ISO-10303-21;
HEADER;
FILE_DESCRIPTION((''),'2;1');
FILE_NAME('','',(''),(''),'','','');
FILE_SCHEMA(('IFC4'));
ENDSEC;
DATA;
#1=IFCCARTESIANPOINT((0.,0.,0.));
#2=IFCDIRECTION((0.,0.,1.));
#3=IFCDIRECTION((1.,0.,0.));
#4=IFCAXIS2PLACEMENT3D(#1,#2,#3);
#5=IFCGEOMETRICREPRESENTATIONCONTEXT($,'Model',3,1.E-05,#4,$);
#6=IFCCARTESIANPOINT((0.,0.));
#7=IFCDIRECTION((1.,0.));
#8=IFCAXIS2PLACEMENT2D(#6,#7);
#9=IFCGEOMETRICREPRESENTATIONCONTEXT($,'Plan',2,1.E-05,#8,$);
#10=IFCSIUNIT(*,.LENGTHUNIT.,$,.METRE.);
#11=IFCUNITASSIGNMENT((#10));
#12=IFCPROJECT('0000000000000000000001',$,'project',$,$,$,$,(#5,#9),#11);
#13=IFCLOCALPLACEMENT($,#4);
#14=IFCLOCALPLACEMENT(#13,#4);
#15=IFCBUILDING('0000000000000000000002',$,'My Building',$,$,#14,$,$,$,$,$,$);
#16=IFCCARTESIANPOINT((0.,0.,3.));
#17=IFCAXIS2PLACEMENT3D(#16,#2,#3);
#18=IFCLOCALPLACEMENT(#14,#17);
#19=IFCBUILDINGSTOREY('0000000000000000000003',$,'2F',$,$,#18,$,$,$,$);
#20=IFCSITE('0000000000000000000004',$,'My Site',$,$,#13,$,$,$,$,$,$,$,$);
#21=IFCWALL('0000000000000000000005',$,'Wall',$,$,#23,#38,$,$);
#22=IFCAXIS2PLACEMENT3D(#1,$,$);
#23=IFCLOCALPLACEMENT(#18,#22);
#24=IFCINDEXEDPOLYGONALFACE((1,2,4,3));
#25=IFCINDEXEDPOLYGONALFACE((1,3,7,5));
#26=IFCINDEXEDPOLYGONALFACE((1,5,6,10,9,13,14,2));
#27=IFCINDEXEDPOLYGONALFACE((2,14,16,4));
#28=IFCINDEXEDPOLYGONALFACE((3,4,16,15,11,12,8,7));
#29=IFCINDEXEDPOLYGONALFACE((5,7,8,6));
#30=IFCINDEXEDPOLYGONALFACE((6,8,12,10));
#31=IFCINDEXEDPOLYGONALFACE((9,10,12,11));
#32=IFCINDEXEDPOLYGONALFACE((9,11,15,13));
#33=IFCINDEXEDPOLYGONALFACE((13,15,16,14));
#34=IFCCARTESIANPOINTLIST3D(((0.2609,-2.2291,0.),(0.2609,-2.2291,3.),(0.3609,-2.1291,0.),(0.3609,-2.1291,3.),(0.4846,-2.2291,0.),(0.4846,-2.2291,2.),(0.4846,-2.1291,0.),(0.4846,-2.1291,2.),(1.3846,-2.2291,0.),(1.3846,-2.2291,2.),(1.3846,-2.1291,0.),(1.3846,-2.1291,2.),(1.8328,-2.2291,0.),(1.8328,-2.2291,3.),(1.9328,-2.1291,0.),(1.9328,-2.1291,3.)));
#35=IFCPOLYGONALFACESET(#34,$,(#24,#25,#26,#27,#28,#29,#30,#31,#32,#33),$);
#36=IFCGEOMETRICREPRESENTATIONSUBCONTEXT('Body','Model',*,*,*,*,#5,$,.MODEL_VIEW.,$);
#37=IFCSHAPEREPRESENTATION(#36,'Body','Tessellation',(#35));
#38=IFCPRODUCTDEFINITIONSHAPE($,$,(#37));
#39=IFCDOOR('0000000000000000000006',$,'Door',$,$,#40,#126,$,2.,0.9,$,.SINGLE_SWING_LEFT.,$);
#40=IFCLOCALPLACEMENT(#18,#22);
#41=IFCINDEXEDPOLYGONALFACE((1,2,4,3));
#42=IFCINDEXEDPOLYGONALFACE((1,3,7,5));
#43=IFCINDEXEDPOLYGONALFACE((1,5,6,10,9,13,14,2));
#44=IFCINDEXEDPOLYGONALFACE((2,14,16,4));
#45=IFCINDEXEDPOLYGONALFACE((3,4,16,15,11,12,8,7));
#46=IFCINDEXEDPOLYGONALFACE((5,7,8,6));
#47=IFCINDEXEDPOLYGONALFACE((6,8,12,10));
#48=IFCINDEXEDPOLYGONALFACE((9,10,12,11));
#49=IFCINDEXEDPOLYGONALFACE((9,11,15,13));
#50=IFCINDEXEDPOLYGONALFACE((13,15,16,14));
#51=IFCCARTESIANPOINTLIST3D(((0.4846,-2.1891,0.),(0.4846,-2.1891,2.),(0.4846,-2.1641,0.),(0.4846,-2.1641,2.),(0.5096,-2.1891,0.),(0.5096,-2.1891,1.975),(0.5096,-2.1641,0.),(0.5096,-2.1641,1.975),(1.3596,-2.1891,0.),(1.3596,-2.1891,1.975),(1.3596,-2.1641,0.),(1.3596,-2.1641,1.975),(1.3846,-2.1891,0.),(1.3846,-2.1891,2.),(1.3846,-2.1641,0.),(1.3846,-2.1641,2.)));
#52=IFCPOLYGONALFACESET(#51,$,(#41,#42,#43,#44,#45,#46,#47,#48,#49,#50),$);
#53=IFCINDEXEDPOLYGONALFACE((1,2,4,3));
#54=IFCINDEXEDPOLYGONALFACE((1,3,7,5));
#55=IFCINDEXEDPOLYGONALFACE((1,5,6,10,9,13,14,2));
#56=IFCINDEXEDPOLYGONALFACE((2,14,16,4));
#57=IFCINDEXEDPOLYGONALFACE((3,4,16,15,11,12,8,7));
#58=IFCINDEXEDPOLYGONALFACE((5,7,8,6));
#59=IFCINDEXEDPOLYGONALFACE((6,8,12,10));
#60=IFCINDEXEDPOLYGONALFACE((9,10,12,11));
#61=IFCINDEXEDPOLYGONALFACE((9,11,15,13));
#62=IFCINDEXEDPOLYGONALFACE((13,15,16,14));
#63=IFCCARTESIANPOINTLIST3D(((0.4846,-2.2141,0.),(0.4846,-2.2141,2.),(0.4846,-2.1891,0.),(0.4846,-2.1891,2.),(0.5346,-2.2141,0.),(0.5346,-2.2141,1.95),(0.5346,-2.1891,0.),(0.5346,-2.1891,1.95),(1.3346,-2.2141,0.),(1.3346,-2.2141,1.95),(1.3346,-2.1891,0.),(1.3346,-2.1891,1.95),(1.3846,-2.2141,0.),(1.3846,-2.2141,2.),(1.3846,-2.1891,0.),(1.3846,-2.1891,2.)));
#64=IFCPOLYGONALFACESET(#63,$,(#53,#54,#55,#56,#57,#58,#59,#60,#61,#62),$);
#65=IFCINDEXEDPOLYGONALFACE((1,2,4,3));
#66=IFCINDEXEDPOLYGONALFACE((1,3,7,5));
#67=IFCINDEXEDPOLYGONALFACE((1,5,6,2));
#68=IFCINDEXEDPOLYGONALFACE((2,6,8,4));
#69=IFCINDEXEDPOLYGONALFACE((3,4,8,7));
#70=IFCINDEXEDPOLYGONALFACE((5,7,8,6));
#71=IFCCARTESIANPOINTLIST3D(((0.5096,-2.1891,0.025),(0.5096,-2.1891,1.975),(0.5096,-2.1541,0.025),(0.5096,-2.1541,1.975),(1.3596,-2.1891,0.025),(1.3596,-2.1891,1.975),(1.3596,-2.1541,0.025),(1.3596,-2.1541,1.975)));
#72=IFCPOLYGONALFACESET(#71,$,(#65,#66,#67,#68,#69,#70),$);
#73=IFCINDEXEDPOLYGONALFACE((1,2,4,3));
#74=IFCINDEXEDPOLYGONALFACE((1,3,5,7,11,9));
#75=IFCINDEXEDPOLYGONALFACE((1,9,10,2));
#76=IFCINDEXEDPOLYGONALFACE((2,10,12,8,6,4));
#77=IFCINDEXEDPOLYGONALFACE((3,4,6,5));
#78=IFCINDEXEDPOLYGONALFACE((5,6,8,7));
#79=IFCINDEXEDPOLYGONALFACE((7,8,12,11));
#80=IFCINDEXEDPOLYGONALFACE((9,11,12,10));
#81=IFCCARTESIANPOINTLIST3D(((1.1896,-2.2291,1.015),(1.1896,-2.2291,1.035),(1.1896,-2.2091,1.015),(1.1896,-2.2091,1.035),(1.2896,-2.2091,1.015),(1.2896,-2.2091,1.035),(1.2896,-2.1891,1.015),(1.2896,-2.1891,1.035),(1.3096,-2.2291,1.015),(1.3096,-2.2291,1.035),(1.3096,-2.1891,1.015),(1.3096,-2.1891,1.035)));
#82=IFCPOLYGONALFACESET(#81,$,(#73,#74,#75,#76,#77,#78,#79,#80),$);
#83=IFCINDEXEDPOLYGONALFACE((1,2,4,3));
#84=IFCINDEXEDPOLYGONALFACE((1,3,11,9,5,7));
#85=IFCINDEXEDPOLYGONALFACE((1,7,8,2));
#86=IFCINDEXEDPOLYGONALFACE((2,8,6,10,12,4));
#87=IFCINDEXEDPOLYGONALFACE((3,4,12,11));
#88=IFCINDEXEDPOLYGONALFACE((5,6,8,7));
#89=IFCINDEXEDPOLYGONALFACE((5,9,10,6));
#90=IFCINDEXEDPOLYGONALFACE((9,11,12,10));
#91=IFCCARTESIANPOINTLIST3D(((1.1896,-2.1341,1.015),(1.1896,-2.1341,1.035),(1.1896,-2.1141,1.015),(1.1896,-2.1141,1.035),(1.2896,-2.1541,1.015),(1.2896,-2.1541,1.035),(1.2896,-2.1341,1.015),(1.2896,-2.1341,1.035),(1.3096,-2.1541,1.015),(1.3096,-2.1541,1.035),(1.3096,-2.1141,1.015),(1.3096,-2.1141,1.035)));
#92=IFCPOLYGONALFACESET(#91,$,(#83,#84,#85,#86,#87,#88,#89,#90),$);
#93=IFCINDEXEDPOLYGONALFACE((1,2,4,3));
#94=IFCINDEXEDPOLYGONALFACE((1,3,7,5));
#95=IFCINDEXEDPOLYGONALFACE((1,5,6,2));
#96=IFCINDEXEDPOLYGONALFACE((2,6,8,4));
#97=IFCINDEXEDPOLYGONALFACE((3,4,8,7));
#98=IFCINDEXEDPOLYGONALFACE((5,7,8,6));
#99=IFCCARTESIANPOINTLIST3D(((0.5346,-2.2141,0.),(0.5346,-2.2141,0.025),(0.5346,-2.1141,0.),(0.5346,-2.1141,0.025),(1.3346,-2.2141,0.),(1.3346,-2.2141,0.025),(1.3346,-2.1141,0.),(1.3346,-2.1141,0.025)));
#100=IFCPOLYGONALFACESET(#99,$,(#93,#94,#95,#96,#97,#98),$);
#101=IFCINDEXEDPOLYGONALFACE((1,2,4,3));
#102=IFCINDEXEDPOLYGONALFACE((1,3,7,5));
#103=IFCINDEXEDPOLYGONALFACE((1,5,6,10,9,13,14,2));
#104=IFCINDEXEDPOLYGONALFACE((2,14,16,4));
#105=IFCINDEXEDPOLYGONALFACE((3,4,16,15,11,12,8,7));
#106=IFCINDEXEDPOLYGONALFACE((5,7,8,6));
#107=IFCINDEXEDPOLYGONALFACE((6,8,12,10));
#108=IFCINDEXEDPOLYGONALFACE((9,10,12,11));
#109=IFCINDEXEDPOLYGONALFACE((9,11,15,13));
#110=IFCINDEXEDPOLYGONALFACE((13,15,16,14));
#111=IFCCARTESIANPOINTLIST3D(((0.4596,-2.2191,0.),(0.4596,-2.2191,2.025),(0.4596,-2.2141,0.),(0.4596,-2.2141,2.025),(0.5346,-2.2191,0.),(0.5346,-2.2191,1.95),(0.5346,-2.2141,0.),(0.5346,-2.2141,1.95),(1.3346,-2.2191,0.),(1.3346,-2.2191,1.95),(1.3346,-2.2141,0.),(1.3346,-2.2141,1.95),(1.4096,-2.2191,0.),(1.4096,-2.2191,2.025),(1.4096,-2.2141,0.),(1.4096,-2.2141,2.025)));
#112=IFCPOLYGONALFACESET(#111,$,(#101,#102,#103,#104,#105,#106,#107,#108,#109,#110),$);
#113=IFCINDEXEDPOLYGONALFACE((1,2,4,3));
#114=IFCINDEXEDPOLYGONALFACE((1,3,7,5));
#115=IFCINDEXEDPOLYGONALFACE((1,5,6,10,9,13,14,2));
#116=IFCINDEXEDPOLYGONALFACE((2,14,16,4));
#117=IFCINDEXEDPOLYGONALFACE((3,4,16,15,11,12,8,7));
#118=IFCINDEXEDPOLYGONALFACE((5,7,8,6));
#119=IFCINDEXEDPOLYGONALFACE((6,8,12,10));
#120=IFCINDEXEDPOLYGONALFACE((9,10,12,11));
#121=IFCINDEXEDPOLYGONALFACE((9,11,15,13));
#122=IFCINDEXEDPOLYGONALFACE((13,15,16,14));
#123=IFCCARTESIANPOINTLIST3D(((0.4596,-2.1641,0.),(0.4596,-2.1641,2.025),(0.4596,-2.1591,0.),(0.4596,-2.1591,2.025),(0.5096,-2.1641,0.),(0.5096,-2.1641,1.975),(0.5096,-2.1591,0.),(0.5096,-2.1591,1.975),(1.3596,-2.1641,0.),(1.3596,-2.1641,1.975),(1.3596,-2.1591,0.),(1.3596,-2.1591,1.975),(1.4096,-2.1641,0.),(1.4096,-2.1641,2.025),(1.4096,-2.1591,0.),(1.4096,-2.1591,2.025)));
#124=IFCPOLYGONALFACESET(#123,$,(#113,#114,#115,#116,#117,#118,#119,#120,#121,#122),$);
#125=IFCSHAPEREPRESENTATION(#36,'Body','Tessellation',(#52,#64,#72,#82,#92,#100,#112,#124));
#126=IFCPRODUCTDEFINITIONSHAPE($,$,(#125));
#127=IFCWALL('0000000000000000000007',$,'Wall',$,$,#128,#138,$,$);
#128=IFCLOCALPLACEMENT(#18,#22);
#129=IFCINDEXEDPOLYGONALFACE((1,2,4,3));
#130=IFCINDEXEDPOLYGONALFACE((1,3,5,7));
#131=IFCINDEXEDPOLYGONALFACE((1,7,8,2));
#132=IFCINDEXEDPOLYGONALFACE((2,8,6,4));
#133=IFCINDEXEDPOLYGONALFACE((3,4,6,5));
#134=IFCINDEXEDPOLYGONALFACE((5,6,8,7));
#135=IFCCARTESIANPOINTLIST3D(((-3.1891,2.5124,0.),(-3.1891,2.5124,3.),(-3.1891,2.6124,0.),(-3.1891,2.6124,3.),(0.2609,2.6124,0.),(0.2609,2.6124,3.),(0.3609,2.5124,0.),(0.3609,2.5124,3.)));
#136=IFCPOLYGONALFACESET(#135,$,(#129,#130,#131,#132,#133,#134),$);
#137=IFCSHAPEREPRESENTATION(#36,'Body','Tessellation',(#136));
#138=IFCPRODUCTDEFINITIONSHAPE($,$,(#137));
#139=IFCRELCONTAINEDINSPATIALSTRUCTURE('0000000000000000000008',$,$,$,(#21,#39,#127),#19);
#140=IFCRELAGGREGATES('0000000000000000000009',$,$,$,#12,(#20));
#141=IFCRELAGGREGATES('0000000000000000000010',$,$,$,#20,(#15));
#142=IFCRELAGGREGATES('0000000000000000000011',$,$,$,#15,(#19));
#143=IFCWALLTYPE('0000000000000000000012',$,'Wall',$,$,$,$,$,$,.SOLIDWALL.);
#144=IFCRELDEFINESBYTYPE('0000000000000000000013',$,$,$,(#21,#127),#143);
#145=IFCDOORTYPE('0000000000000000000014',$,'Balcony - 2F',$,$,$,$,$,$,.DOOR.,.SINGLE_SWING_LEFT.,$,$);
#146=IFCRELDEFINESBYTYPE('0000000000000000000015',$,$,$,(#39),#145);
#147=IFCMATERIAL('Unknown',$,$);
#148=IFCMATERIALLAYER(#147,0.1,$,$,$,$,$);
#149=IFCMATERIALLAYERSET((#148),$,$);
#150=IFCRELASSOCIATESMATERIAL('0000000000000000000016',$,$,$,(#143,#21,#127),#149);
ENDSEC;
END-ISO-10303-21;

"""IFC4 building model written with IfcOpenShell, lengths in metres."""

from ifc_helpers import new_model, entity, si_unit, frame, origin_with_axes, origin_2d_with_axis, place, context, subcontext, project, spatial, line, indexed_curve, outline, extrude, shape, source, transform, mapped, material, layer, layer_set, layer_usage, type_object, type_shapes, element, fill, save


model = new_model("IFC4")

# Units and contexts
model_context = context("Model", 3, precision=1e-05, world=origin_with_axes())
plan_context = context("Plan", 2, precision=1e-05, world=origin_2d_with_axis())
body_context_1 = subcontext(model_context, "Body", "Model", "MODEL_VIEW")
body_context_2 = subcontext(plan_context, "Body", "Plan", "PLAN_VIEW")
ifc_project = project(units=[si_unit("LENGTHUNIT", "METRE")], contexts=[model_context, plan_context])

# Site, building, storey
site_placement = place(None, origin_with_axes())
site = spatial("IfcSite", under=ifc_project, at=site_placement, Name="My Site")
building_placement = place(site_placement, origin_with_axes())
building = spatial("IfcBuilding", under=site, at=building_placement, Name="My Building")
storey_placement = place(building_placement, frame((0.0, 0.0, 3.0), z_axis=(0.0, 0.0, 1.0), x_axis=(1.0, 0.0, 0.0)))
storey = spatial("IfcBuildingStorey", under=building, at=storey_placement, Name="2F")

# Shared definitions
ifc_material = material(Name="Unknown")

# Shared definitions
ifc_layer = layer(ifc_material, 0.1)
ifc_layer_set = layer_set([ifc_layer])
wall_type = type_object("IfcWallType", Name="Wall", PredefinedType="SOLIDWALL", material=ifc_layer_set)

# Wall, opening, door
ifc_layer_usage_1 = layer_usage(ifc_layer_set, "AXIS2", "POSITIVE", 0.0)
wall_1_placement = place(storey_placement, frame((0.2609, -2.2291, 0.0), z_axis=(0.0, 0.0, 1.0), x_axis=(1.0, 0.0, 0.0)))
wall_1 = element("IfcWall", 1, at=wall_1_placement, inside=storey, type_object=wall_type, material=ifc_layer_usage_1, Name="Wall", context=body_context_1, shape_type="SweptSolid", body=[
    extrude(outline(indexed_curve([(0.0, 0.0), (0.1, 0.1), (1.6718, 0.1), (1.5718, 0.0)], segments=[line(1, 2, 3, 4, 1)])), origin_with_axes(), (0.0, 0.0, 1.0), 3.0),
])
shared_shape_1 = source(origin_with_axes(), body_context_1, "Body", "SweptSolid", [
    extrude(outline(indexed_curve([(0.0, 0.0), (0.9, 0.0), (0.9, 2.0), (0.0, 2.0)], segments=[line(1, 2, 3, 4, 1)])), frame((0.0, -0.6, 0.0), z_axis=(0.0, -1.0, 0.0), x_axis=(1.0, 0.0, 0.0)), (0.0, 0.0, -1.0), 1.2),
])
opening_1_placement = place(wall_1_placement, frame((0.2236, 0.015, 0.0), z_axis=(0.0, 0.0, 1.0), x_axis=(1.0, 0.0, 0.0)))
opening_1 = element("IfcOpeningElement", 2, at=opening_1_placement, cuts=wall_1, PredefinedType="OPENING", context=body_context_1, shape_type="MappedRepresentation", body=[
    mapped(shared_shape_1, transform((0.0, 0.0, 0.0), x_axis=(1.0, 0.0, 0.0), y_axis=(0.0, 1.0, 0.0), z_axis=(0.0, 0.0, 1.0), scale=1.0)),
])
door_type_1 = type_object("IfcDoorType", Name="Balcony - 2F", OperationType="SINGLE_SWING_LEFT", PredefinedType="DOOR")
shared_shape_2 = source(origin_with_axes(), body_context_1, "Body", "SweptSolid", [
    extrude(outline(indexed_curve([(0.0, 0.0), (0.0, 2.0), (0.9, 2.0), (0.9, 0.0), (0.875, 0.0), (0.875, 1.975), (0.025, 1.975), (0.025, 0.0)], segments=[line(1, 2, 3, 4, 5, 6, 7, 8, 1)])), frame((0.0, 0.025, 0.0), z_axis=(0.0, -1.0, 0.0), x_axis=(1.0, 0.0, 0.0)), (0.0, 0.0, -1.0), 0.025),
    extrude(outline(indexed_curve([(0.0, 0.0), (0.0, 2.0), (0.9, 2.0), (0.9, 0.0), (0.85, 0.0), (0.85, 1.95), (0.05, 1.95), (0.05, 0.0)], segments=[line(1, 2, 3, 4, 5, 6, 7, 8, 1)])), frame((0.0, 0.0, 0.0), z_axis=(0.0, -1.0, 0.0), x_axis=(1.0, 0.0, 0.0)), (0.0, 0.0, -1.0), 0.025),
    extrude(outline(indexed_curve([(0.0, 0.0), (0.85, 0.0), (0.85, 0.035), (0.0, 0.035)], segments=[line(1, 2, 3, 4, 1)])), frame((0.025, 0.025, 0.025), z_axis=(0.0, 0.0, 1.0), x_axis=(1.0, 0.0, 0.0)), (0.0, 0.0, 1.0), 1.95),
    extrude(outline(indexed_curve([(0.0, 0.0), (0.0, -0.04), (-0.12, -0.04), (-0.12, -0.02), (-0.02, -0.02), (-0.02, 0.0)], segments=[line(1, 2, 3, 4, 5, 6, 1)])), frame((0.825, 0.025, 1.015), z_axis=(0.0, 0.0, 1.0), x_axis=(1.0, 0.0, 0.0)), (0.0, 0.0, 1.0), 0.02),
    extrude(outline(indexed_curve([(0.0, 0.0), (0.0, 0.04), (-0.12, 0.04), (-0.12, 0.02), (-0.02, 0.02), (-0.02, 0.0)], segments=[line(1, 2, 3, 4, 5, 6, 1)])), frame((0.825, 0.06, 1.015), z_axis=(0.0, 0.0, 1.0), x_axis=(1.0, 0.0, 0.0)), (0.0, 0.0, 1.0), 0.02),
    extrude(outline(indexed_curve([(0.0, 0.0), (0.8, 0.0), (0.8, 0.1), (0.0, 0.1)], segments=[line(1, 2, 3, 4, 1)])), frame((0.05, 0.0, 0.0), z_axis=(0.0, 0.0, 1.0), x_axis=(1.0, 0.0, 0.0)), (0.0, 0.0, 1.0), 0.025),
    extrude(outline(indexed_curve([(0.0, 0.0), (0.0, 2.025), (0.95, 2.025), (0.95, 0.0), (0.875, 0.0), (0.875, 1.95), (0.075, 1.95), (0.075, 0.0)], segments=[line(1, 2, 3, 4, 5, 6, 7, 8, 1)])), frame((-0.025, -0.005, 0.0), z_axis=(0.0, -1.0, 0.0), x_axis=(1.0, 0.0, 0.0)), (0.0, 0.0, -1.0), 0.005),
    extrude(outline(indexed_curve([(0.0, 0.0), (0.0, 2.025), (0.95, 2.025), (0.95, 0.0), (0.9, 0.0), (0.9, 1.975), (0.05, 1.975), (0.05, 0.0)], segments=[line(1, 2, 3, 4, 5, 6, 7, 8, 1)])), frame((-0.025, 0.05, 0.0), z_axis=(0.0, -1.0, 0.0), x_axis=(1.0, 0.0, 0.0)), (0.0, 0.0, -1.0), 0.005),
])
shared_shape_3 = source(origin_with_axes(), body_context_2, "Body", "Curve2D", [
    entity("IfcIndexedPolyCurve", entity("IfcCartesianPointList2D", [[0.0, 0.0], [0.0, 0.05], [0.025, 0.05], [0.025, 0.025], [0.05, 0.025], [0.05, 0.0]]), [entity("IfcLineIndex", [1, 2, 3, 4, 5, 6, 1])]),
    entity("IfcIndexedPolyCurve", entity("IfcCartesianPointList2D", [[0.9, 0.0], [0.9, 0.05], [0.875, 0.05], [0.875, 0.025], [0.85, 0.025], [0.85, 0.0]]), [entity("IfcLineIndex", [1, 2, 3, 4, 5, 6, 1])]),
    entity("IfcTrimmedCurve", entity("IfcEllipse", entity("IfcAxis2Placement2D", entity("IfcCartesianPoint", [0.06, 0.05]), entity("IfcDirection", [1.0, 0.0])), 0.815, 0.85), [entity("IfcCartesianPoint", [0.875, 0.05])], [entity("IfcCartesianPoint", [0.06, 0.9])], True, "CARTESIAN"),
    entity("IfcIndexedPolyCurve", entity("IfcCartesianPointList2D", [[0.025, 0.05], [0.06, 0.05], [0.06, 0.9], [0.025, 0.9]]), [entity("IfcLineIndex", [1, 2, 3, 4, 1])]),
])
type_shapes(door_type_1, [shared_shape_2, shared_shape_3])
door_1_placement = place(opening_1_placement, frame((0.0, 0.0, 0.0), z_axis=(0.0, 0.0, 1.0), x_axis=(1.0, 0.0, 0.0)))
door_1 = element("IfcDoor", 3, at=door_1_placement, inside=storey, type_object=door_type_1, Name="Door", OperationType="SINGLE_SWING_LEFT", OverallHeight=2.0, OverallWidth=0.9, shapes=[
    shape(body_context_1, "Body", "MappedRepresentation", [mapped(shared_shape_2, transform((0.0, 0.0, 0.0), x_axis=(1.0, 0.0, 0.0), y_axis=(0.0, 1.0, 0.0), z_axis=(0.0, 0.0, 1.0), scale=1.0))]),
    shape(body_context_2, "Body", "MappedRepresentation", [mapped(shared_shape_3, transform((0.0, 0.0, 0.0), x_axis=(1.0, 0.0, 0.0), y_axis=(0.0, 1.0, 0.0), z_axis=(0.0, 0.0, 1.0), scale=1.0))]),
])
fill(opening_1, door_1)

# Wall
ifc_layer_usage_2 = layer_usage(ifc_layer_set, "AXIS2", "POSITIVE", 0.0)
wall_2_placement = place(storey_placement, frame((-3.1891, 2.5124, 0.0), z_axis=(0.0, 0.0, 1.0), x_axis=(1.0, 0.0, 0.0)))
element("IfcWall", 4, at=wall_2_placement, inside=storey, type_object=wall_type, material=ifc_layer_usage_2, Name="Wall", context=body_context_1, shape_type="SweptSolid", body=[
    extrude(outline(indexed_curve([(0.0, 0.0), (0.0, 0.1), (3.45, 0.1), (3.55, 0.0)], segments=[line(1, 2, 3, 4, 1)])), origin_with_axes(), (0.0, 0.0, 1.0), 3.0),
])

save(model, "model.ifc")
